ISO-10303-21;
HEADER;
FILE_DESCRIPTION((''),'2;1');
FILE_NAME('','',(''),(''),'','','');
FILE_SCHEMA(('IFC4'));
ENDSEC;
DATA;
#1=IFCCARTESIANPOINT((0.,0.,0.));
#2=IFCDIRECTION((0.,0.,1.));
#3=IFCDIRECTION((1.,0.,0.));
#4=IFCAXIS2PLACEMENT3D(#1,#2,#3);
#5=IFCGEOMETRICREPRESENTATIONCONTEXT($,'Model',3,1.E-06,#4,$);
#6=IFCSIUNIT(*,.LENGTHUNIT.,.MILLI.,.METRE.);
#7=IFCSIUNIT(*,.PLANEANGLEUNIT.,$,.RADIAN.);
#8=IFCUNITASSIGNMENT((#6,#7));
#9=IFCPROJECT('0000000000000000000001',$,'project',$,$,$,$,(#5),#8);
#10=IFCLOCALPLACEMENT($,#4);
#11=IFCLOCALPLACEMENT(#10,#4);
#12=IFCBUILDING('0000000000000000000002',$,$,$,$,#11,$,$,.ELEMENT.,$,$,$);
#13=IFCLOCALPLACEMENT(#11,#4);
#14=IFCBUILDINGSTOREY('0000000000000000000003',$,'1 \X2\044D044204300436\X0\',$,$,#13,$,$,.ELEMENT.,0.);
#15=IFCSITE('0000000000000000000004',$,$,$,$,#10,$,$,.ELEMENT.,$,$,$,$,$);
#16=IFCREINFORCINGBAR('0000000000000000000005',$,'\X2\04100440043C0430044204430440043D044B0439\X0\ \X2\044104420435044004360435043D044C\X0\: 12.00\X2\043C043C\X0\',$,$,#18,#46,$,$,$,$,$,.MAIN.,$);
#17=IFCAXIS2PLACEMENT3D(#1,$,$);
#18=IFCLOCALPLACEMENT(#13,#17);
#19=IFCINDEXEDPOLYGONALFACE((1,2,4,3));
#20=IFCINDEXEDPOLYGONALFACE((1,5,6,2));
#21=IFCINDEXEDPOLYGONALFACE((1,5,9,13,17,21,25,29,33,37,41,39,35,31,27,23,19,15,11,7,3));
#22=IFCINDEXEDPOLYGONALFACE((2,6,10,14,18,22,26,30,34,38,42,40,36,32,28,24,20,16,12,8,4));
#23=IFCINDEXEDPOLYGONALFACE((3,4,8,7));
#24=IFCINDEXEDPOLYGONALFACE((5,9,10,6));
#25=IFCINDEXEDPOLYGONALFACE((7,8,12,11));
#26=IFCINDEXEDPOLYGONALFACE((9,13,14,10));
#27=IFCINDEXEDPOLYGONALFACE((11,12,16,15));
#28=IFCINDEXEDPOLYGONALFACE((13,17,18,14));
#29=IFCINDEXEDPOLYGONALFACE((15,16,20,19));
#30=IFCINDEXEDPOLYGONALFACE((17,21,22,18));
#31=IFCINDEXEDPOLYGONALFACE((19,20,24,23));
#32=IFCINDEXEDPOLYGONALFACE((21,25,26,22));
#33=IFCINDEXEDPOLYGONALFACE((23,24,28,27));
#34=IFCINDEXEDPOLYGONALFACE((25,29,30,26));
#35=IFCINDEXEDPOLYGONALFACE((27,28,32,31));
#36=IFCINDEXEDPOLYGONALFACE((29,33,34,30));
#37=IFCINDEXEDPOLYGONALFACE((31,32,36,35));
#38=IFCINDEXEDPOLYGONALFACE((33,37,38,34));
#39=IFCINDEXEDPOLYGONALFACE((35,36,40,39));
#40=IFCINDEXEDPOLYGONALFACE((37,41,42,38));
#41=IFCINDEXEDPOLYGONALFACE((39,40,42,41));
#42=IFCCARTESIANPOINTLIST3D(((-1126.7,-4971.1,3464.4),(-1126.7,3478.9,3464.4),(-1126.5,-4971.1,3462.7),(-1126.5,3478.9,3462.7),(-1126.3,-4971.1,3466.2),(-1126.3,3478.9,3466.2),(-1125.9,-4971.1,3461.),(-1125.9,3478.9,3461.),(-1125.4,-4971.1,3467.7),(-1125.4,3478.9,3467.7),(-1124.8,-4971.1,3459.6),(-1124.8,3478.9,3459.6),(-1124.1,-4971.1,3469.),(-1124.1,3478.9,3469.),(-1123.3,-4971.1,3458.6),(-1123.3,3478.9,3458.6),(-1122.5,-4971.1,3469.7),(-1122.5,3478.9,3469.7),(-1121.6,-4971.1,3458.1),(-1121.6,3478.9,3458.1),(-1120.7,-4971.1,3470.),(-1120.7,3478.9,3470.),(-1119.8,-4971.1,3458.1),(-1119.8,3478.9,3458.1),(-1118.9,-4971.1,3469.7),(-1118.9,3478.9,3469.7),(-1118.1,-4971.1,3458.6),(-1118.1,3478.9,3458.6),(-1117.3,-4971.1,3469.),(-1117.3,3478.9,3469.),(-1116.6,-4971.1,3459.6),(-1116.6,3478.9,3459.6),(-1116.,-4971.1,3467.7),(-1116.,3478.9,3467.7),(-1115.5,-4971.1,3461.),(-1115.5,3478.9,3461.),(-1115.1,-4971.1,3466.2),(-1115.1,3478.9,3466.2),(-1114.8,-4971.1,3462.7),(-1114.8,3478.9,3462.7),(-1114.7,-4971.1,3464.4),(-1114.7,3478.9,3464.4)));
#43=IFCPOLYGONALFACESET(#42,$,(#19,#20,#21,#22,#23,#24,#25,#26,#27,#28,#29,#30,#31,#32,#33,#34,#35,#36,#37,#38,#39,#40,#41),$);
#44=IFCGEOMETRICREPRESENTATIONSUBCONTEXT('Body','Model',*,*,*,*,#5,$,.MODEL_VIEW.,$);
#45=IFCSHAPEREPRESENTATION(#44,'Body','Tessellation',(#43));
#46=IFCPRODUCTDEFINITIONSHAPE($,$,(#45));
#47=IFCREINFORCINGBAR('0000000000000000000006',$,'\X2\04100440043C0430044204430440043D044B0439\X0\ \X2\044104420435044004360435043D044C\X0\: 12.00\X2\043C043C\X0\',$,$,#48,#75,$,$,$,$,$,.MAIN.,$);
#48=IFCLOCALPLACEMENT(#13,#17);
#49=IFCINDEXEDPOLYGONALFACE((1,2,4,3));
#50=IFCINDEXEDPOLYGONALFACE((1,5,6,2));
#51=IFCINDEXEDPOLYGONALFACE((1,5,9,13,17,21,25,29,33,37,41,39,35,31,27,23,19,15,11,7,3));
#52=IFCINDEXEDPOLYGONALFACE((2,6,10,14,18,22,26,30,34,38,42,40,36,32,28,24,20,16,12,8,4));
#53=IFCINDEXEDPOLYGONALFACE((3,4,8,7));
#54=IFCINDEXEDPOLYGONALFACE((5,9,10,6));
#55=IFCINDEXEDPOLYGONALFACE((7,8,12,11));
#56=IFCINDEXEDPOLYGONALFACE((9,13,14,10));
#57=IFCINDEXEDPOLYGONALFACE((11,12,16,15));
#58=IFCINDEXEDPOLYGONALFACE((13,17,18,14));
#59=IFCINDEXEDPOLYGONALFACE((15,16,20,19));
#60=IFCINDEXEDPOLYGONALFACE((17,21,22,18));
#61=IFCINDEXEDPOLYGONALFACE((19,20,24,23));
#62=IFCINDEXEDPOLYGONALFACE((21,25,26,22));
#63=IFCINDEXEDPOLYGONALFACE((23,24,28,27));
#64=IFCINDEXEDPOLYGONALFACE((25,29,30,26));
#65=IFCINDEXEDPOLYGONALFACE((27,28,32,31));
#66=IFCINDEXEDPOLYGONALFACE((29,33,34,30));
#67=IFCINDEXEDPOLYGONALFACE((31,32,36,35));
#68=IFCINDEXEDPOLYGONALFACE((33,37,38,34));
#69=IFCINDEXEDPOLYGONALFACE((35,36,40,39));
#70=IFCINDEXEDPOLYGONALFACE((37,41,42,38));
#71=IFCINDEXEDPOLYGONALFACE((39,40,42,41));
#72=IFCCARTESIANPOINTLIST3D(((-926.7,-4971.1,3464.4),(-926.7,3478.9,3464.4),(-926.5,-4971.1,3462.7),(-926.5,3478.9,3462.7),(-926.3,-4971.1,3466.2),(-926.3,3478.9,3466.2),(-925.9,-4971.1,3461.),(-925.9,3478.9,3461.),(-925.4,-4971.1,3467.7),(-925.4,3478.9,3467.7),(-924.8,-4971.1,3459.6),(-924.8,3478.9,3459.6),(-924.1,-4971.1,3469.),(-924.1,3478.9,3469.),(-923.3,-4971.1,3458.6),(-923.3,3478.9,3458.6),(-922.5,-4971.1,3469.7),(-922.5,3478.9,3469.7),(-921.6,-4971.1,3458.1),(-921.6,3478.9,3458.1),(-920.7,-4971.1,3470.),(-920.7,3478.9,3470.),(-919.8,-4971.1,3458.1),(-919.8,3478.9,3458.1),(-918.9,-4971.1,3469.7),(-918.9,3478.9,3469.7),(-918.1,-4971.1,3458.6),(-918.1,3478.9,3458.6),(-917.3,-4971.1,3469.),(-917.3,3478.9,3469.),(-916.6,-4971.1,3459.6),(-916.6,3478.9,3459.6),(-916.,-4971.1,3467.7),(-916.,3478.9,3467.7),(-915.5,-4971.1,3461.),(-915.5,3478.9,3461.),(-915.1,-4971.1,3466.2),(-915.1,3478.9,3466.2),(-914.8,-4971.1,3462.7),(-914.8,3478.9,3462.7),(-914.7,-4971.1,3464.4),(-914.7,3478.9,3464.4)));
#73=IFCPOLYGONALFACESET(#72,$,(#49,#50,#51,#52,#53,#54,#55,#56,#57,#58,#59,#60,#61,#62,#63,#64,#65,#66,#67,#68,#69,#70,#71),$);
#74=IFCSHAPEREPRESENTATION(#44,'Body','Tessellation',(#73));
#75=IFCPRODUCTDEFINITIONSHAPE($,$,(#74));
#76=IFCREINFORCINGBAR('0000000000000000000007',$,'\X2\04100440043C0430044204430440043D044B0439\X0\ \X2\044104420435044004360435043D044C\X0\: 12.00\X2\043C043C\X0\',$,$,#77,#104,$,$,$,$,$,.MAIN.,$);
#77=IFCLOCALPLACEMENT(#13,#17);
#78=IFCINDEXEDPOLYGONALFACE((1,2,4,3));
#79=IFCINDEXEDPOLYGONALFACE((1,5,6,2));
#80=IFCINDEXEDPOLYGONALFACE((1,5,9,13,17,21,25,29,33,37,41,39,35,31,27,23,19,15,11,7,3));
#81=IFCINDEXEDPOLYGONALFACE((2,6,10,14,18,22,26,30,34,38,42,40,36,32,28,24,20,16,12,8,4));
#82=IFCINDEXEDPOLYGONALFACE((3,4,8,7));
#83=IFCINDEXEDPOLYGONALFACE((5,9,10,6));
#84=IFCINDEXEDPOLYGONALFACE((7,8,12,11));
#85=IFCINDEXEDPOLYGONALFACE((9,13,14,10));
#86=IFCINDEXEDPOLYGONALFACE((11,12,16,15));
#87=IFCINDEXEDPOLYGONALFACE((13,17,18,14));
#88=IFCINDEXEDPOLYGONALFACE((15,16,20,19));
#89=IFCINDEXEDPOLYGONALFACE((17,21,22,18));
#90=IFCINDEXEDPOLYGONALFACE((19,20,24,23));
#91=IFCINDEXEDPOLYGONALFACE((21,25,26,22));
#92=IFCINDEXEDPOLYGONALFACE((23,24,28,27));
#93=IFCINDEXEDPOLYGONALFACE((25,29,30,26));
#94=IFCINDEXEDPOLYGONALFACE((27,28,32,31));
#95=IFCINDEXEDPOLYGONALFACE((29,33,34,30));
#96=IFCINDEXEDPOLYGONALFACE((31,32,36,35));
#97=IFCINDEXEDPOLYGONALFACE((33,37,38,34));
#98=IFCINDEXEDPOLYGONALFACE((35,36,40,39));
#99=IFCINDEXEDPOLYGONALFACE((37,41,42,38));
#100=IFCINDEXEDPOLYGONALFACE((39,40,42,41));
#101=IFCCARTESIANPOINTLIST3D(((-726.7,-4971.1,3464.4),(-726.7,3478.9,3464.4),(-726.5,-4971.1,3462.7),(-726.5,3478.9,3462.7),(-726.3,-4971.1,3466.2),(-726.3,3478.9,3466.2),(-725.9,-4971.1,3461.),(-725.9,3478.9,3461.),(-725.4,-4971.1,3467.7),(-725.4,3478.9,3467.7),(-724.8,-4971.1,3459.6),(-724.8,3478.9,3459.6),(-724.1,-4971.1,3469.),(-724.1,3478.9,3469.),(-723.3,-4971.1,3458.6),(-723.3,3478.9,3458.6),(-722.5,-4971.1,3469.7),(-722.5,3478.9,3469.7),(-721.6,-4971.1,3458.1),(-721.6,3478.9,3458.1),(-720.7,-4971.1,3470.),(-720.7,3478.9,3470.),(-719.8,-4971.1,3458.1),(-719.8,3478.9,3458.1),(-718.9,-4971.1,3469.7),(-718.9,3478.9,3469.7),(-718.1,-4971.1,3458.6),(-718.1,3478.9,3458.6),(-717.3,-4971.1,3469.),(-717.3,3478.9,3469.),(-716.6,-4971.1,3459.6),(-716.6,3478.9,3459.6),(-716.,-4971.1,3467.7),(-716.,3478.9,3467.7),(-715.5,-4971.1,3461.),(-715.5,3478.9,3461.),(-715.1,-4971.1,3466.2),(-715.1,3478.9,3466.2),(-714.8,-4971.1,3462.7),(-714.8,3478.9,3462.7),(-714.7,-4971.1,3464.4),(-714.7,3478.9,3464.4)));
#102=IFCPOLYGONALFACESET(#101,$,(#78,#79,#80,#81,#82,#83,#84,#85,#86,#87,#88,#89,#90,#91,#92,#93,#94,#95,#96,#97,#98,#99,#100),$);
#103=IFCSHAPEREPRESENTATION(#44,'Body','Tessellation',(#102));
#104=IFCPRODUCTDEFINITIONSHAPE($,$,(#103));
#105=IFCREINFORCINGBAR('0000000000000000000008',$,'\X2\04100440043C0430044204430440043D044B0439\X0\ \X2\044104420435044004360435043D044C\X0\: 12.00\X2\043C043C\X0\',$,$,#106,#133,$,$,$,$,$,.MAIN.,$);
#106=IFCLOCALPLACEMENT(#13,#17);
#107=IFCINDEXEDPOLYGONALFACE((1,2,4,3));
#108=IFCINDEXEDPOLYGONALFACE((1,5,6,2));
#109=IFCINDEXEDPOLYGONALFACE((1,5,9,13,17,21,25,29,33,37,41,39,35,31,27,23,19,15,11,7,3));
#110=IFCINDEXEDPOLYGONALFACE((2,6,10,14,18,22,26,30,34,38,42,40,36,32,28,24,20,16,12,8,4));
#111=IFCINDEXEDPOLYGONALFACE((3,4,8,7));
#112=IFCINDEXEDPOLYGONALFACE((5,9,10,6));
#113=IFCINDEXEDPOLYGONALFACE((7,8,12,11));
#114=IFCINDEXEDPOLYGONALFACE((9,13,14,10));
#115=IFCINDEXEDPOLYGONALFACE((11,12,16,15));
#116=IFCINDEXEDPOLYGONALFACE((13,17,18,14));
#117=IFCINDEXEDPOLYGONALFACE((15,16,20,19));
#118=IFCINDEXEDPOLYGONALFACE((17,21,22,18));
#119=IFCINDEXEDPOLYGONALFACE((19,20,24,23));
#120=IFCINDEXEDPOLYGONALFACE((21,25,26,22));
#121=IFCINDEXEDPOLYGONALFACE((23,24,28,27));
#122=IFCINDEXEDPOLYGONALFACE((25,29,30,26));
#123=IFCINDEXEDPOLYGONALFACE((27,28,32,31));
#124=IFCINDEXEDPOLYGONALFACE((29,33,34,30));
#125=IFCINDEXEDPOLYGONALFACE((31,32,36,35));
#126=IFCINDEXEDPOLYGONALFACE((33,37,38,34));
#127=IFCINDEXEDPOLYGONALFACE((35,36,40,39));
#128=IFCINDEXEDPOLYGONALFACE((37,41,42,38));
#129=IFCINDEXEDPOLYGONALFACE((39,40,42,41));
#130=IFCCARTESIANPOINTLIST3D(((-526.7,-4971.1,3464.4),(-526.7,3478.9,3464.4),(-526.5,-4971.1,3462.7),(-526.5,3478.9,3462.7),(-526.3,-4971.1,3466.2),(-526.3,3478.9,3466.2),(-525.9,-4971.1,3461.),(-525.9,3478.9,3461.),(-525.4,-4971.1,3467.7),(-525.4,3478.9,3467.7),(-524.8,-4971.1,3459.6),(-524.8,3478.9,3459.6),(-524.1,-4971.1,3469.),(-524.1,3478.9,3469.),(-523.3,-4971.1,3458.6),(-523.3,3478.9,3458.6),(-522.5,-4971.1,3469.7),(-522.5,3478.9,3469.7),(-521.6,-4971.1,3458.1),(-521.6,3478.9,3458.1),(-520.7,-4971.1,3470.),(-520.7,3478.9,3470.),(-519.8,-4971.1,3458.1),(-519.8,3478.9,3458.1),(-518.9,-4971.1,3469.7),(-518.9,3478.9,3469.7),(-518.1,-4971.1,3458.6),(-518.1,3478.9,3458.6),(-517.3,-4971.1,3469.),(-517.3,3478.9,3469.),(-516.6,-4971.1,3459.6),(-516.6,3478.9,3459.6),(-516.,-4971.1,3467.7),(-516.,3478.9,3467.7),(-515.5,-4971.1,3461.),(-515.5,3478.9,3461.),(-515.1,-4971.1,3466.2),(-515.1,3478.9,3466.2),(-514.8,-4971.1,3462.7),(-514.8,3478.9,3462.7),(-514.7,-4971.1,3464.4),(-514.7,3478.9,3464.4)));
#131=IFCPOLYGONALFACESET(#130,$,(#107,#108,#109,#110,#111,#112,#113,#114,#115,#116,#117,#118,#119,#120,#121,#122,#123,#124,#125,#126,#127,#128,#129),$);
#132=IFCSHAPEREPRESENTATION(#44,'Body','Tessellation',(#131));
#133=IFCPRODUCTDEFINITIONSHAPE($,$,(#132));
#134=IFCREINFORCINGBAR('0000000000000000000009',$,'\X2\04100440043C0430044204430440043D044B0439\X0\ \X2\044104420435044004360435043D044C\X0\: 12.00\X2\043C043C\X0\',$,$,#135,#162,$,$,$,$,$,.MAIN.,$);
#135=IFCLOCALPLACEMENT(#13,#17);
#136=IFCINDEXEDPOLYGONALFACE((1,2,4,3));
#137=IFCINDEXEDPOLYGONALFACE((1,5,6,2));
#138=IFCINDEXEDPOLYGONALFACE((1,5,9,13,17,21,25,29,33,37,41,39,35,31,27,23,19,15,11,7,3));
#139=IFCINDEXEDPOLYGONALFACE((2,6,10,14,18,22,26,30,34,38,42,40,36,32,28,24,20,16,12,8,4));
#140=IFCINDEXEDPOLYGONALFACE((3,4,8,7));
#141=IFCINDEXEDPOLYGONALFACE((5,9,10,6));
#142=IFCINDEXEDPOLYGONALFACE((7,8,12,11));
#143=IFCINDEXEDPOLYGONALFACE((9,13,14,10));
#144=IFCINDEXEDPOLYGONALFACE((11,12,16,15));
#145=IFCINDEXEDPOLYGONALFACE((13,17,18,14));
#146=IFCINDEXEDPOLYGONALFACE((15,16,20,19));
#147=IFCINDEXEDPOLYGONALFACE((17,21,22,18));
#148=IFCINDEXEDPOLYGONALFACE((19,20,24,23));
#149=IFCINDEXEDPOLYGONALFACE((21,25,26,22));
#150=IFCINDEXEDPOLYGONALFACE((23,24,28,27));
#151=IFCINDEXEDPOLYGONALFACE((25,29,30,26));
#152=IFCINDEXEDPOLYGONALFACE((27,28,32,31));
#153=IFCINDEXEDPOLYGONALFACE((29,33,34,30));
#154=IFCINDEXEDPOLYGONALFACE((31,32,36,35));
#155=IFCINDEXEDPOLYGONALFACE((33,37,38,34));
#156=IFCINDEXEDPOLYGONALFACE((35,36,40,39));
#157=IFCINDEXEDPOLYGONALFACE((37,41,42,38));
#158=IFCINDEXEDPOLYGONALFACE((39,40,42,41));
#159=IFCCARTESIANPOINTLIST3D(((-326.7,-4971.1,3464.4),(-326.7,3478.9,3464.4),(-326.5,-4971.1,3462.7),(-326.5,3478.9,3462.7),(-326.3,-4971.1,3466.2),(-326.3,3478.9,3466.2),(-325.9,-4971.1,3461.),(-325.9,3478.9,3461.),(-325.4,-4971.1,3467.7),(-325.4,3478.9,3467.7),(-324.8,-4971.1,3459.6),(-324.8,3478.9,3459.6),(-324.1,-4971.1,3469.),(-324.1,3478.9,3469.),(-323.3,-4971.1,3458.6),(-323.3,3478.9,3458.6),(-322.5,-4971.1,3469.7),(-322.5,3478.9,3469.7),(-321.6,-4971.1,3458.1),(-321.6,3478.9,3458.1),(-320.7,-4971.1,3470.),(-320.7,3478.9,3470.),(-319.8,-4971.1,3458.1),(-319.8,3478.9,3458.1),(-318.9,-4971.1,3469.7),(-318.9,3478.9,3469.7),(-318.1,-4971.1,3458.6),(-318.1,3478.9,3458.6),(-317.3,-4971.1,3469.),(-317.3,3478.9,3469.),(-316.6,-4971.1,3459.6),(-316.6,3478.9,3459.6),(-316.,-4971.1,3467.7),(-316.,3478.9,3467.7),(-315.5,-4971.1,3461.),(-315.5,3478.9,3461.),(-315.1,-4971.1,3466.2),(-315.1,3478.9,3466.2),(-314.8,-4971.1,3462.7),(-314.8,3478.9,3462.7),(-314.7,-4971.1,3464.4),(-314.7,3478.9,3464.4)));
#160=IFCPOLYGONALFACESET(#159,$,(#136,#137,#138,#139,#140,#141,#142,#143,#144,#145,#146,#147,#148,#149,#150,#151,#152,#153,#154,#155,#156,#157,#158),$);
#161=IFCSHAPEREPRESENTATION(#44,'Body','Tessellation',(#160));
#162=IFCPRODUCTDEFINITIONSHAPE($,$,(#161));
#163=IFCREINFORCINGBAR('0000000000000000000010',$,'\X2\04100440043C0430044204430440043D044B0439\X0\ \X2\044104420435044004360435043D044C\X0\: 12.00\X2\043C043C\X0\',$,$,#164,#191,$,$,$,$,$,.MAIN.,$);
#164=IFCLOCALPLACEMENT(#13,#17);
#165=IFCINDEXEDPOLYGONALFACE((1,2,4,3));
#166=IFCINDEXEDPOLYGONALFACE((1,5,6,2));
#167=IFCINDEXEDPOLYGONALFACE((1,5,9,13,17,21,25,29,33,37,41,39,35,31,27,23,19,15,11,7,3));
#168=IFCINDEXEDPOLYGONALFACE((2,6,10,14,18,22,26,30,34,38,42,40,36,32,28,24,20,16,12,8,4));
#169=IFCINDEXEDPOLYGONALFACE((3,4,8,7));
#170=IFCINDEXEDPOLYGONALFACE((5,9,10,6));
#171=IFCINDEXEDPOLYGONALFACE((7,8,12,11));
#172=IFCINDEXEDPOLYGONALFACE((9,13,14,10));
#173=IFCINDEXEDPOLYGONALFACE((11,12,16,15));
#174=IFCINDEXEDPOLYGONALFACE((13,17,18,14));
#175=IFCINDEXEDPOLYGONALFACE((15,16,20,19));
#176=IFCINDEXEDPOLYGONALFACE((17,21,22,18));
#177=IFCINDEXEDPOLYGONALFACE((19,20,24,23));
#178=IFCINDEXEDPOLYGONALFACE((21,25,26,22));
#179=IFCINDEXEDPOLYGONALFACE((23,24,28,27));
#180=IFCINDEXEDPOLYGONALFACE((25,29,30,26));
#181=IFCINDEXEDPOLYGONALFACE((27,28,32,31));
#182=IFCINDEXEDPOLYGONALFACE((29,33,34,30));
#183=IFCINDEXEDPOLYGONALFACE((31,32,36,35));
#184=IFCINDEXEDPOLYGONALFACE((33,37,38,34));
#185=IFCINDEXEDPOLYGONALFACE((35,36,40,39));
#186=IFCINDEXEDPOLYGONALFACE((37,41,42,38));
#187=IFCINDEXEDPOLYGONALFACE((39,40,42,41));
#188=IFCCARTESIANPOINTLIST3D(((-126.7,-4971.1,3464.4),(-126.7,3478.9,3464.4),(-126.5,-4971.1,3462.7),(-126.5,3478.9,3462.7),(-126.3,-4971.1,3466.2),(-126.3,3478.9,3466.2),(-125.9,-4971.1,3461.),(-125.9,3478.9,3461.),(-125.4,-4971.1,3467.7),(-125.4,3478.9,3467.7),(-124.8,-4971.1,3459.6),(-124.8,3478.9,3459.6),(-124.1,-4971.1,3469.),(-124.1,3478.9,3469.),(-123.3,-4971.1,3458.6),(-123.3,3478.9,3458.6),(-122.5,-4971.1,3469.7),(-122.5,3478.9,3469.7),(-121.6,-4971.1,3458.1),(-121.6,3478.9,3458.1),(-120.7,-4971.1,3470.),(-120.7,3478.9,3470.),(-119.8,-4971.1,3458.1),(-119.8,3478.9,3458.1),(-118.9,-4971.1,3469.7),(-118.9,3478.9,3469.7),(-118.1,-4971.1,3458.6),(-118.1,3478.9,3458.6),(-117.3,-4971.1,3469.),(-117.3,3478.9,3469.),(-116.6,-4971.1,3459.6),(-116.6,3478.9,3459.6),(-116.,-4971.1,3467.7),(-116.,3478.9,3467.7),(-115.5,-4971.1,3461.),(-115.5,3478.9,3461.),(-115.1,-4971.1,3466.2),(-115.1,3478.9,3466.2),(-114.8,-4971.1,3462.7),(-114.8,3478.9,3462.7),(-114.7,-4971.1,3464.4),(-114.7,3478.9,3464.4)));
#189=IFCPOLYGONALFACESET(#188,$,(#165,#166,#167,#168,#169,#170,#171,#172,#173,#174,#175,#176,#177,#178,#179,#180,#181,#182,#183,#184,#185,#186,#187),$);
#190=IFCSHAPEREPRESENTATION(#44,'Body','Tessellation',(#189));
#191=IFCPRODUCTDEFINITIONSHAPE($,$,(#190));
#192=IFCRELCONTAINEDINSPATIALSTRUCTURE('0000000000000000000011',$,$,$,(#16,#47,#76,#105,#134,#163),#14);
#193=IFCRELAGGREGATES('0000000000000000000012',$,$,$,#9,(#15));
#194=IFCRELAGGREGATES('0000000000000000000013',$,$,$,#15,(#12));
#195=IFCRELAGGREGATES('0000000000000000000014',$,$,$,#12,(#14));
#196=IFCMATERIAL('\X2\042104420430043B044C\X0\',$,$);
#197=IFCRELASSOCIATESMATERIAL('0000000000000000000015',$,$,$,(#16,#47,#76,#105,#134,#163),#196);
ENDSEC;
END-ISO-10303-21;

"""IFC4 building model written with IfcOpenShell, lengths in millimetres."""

from ifc_helpers import new_model, entity, si_unit, origin_with_axes, place, context, subcontext, project, spatial, source, transform, mapped, material, element, save


model = new_model("IFC4")

# Units and contexts
model_context = context("Model", 3, precision=1e-06, world=origin_with_axes())
body_context = subcontext(model_context, "Body", "Model", "MODEL_VIEW")
ifc_project = project(units=[si_unit("LENGTHUNIT", "METRE", prefix="MILLI"), si_unit("PLANEANGLEUNIT", "RADIAN")], contexts=[model_context])

# Site, building, storey
site_placement = place(None, origin_with_axes())
site = spatial("IfcSite", under=ifc_project, at=site_placement, CompositionType="ELEMENT")
building_placement = place(site_placement, origin_with_axes())
building = spatial("IfcBuilding", under=site, at=building_placement, CompositionType="ELEMENT")
storey_placement = place(building_placement, origin_with_axes())
storey = spatial("IfcBuildingStorey", under=building, at=storey_placement, Name="1 этаж", CompositionType="ELEMENT", Elevation=0.0)

# Reinforcing bars
ifc_material = material(Name="Сталь")
shared_shape = source(origin_with_axes(), body_context, "Body", "AdvancedSweptSolid", [
    entity("IfcSweptDiskSolid", entity("IfcIndexedPolyCurve", entity("IfcCartesianPointList3D", [[0.0, 0.0, 0.0], [8450.0, 0.0, 0.0]]), [entity("IfcLineIndex", [1, 2])]), 6.0),
])
reinforcing_bar_1_placement = place(storey_placement, origin_with_axes())
element("IfcReinforcingBar", 1, at=reinforcing_bar_1_placement, inside=storey, material=ifc_material, Name="Арматурный стержень: 12.00мм", PredefinedType="MAIN", context=body_context, shape_type="MappedRepresentation", body=[
    mapped(shared_shape, transform((-1120.7, -4971.1, 3464.0), x_axis=(0.0, 1.0, 0.0), y_axis=(-1.0, 0.0, 0.0), z_axis=(0.0, 0.0, 1.0), scale=1.0)),
])
reinforcing_bar_2_placement = place(storey_placement, origin_with_axes())
element("IfcReinforcingBar", 2, at=reinforcing_bar_2_placement, inside=storey, material=ifc_material, Name="Арматурный стержень: 12.00мм", PredefinedType="MAIN", context=body_context, shape_type="MappedRepresentation", body=[
    mapped(shared_shape, transform((-920.7, -4971.1, 3464.0), x_axis=(0.0, 1.0, 0.0), y_axis=(-1.0, 0.0, 0.0), z_axis=(0.0, 0.0, 1.0), scale=1.0)),
])
reinforcing_bar_3_placement = place(storey_placement, origin_with_axes())
element("IfcReinforcingBar", 3, at=reinforcing_bar_3_placement, inside=storey, material=ifc_material, Name="Арматурный стержень: 12.00мм", PredefinedType="MAIN", context=body_context, shape_type="MappedRepresentation", body=[
    mapped(shared_shape, transform((-720.7, -4971.1, 3464.0), x_axis=(0.0, 1.0, 0.0), y_axis=(-1.0, 0.0, 0.0), z_axis=(0.0, 0.0, 1.0), scale=1.0)),
])
reinforcing_bar_4_placement = place(storey_placement, origin_with_axes())
element("IfcReinforcingBar", 4, at=reinforcing_bar_4_placement, inside=storey, material=ifc_material, Name="Арматурный стержень: 12.00мм", PredefinedType="MAIN", context=body_context, shape_type="MappedRepresentation", body=[
    mapped(shared_shape, transform((-520.7, -4971.1, 3464.0), x_axis=(0.0, 1.0, 0.0), y_axis=(-1.0, 0.0, 0.0), z_axis=(0.0, 0.0, 1.0), scale=1.0)),
])
reinforcing_bar_5_placement = place(storey_placement, origin_with_axes())
element("IfcReinforcingBar", 5, at=reinforcing_bar_5_placement, inside=storey, material=ifc_material, Name="Арматурный стержень: 12.00мм", PredefinedType="MAIN", context=body_context, shape_type="MappedRepresentation", body=[
    mapped(shared_shape, transform((-320.7, -4971.1, 3464.0), x_axis=(0.0, 1.0, 0.0), y_axis=(-1.0, 0.0, 0.0), z_axis=(0.0, 0.0, 1.0), scale=1.0)),
])
reinforcing_bar_6_placement = place(storey_placement, origin_with_axes())
element("IfcReinforcingBar", 6, at=reinforcing_bar_6_placement, inside=storey, material=ifc_material, Name="Арматурный стержень: 12.00мм", PredefinedType="MAIN", context=body_context, shape_type="MappedRepresentation", body=[
    mapped(shared_shape, transform((-120.7, -4971.1, 3464.0), x_axis=(0.0, 1.0, 0.0), y_axis=(-1.0, 0.0, 0.0), z_axis=(0.0, 0.0, 1.0), scale=1.0)),
])

save(model, "model.ifc")
